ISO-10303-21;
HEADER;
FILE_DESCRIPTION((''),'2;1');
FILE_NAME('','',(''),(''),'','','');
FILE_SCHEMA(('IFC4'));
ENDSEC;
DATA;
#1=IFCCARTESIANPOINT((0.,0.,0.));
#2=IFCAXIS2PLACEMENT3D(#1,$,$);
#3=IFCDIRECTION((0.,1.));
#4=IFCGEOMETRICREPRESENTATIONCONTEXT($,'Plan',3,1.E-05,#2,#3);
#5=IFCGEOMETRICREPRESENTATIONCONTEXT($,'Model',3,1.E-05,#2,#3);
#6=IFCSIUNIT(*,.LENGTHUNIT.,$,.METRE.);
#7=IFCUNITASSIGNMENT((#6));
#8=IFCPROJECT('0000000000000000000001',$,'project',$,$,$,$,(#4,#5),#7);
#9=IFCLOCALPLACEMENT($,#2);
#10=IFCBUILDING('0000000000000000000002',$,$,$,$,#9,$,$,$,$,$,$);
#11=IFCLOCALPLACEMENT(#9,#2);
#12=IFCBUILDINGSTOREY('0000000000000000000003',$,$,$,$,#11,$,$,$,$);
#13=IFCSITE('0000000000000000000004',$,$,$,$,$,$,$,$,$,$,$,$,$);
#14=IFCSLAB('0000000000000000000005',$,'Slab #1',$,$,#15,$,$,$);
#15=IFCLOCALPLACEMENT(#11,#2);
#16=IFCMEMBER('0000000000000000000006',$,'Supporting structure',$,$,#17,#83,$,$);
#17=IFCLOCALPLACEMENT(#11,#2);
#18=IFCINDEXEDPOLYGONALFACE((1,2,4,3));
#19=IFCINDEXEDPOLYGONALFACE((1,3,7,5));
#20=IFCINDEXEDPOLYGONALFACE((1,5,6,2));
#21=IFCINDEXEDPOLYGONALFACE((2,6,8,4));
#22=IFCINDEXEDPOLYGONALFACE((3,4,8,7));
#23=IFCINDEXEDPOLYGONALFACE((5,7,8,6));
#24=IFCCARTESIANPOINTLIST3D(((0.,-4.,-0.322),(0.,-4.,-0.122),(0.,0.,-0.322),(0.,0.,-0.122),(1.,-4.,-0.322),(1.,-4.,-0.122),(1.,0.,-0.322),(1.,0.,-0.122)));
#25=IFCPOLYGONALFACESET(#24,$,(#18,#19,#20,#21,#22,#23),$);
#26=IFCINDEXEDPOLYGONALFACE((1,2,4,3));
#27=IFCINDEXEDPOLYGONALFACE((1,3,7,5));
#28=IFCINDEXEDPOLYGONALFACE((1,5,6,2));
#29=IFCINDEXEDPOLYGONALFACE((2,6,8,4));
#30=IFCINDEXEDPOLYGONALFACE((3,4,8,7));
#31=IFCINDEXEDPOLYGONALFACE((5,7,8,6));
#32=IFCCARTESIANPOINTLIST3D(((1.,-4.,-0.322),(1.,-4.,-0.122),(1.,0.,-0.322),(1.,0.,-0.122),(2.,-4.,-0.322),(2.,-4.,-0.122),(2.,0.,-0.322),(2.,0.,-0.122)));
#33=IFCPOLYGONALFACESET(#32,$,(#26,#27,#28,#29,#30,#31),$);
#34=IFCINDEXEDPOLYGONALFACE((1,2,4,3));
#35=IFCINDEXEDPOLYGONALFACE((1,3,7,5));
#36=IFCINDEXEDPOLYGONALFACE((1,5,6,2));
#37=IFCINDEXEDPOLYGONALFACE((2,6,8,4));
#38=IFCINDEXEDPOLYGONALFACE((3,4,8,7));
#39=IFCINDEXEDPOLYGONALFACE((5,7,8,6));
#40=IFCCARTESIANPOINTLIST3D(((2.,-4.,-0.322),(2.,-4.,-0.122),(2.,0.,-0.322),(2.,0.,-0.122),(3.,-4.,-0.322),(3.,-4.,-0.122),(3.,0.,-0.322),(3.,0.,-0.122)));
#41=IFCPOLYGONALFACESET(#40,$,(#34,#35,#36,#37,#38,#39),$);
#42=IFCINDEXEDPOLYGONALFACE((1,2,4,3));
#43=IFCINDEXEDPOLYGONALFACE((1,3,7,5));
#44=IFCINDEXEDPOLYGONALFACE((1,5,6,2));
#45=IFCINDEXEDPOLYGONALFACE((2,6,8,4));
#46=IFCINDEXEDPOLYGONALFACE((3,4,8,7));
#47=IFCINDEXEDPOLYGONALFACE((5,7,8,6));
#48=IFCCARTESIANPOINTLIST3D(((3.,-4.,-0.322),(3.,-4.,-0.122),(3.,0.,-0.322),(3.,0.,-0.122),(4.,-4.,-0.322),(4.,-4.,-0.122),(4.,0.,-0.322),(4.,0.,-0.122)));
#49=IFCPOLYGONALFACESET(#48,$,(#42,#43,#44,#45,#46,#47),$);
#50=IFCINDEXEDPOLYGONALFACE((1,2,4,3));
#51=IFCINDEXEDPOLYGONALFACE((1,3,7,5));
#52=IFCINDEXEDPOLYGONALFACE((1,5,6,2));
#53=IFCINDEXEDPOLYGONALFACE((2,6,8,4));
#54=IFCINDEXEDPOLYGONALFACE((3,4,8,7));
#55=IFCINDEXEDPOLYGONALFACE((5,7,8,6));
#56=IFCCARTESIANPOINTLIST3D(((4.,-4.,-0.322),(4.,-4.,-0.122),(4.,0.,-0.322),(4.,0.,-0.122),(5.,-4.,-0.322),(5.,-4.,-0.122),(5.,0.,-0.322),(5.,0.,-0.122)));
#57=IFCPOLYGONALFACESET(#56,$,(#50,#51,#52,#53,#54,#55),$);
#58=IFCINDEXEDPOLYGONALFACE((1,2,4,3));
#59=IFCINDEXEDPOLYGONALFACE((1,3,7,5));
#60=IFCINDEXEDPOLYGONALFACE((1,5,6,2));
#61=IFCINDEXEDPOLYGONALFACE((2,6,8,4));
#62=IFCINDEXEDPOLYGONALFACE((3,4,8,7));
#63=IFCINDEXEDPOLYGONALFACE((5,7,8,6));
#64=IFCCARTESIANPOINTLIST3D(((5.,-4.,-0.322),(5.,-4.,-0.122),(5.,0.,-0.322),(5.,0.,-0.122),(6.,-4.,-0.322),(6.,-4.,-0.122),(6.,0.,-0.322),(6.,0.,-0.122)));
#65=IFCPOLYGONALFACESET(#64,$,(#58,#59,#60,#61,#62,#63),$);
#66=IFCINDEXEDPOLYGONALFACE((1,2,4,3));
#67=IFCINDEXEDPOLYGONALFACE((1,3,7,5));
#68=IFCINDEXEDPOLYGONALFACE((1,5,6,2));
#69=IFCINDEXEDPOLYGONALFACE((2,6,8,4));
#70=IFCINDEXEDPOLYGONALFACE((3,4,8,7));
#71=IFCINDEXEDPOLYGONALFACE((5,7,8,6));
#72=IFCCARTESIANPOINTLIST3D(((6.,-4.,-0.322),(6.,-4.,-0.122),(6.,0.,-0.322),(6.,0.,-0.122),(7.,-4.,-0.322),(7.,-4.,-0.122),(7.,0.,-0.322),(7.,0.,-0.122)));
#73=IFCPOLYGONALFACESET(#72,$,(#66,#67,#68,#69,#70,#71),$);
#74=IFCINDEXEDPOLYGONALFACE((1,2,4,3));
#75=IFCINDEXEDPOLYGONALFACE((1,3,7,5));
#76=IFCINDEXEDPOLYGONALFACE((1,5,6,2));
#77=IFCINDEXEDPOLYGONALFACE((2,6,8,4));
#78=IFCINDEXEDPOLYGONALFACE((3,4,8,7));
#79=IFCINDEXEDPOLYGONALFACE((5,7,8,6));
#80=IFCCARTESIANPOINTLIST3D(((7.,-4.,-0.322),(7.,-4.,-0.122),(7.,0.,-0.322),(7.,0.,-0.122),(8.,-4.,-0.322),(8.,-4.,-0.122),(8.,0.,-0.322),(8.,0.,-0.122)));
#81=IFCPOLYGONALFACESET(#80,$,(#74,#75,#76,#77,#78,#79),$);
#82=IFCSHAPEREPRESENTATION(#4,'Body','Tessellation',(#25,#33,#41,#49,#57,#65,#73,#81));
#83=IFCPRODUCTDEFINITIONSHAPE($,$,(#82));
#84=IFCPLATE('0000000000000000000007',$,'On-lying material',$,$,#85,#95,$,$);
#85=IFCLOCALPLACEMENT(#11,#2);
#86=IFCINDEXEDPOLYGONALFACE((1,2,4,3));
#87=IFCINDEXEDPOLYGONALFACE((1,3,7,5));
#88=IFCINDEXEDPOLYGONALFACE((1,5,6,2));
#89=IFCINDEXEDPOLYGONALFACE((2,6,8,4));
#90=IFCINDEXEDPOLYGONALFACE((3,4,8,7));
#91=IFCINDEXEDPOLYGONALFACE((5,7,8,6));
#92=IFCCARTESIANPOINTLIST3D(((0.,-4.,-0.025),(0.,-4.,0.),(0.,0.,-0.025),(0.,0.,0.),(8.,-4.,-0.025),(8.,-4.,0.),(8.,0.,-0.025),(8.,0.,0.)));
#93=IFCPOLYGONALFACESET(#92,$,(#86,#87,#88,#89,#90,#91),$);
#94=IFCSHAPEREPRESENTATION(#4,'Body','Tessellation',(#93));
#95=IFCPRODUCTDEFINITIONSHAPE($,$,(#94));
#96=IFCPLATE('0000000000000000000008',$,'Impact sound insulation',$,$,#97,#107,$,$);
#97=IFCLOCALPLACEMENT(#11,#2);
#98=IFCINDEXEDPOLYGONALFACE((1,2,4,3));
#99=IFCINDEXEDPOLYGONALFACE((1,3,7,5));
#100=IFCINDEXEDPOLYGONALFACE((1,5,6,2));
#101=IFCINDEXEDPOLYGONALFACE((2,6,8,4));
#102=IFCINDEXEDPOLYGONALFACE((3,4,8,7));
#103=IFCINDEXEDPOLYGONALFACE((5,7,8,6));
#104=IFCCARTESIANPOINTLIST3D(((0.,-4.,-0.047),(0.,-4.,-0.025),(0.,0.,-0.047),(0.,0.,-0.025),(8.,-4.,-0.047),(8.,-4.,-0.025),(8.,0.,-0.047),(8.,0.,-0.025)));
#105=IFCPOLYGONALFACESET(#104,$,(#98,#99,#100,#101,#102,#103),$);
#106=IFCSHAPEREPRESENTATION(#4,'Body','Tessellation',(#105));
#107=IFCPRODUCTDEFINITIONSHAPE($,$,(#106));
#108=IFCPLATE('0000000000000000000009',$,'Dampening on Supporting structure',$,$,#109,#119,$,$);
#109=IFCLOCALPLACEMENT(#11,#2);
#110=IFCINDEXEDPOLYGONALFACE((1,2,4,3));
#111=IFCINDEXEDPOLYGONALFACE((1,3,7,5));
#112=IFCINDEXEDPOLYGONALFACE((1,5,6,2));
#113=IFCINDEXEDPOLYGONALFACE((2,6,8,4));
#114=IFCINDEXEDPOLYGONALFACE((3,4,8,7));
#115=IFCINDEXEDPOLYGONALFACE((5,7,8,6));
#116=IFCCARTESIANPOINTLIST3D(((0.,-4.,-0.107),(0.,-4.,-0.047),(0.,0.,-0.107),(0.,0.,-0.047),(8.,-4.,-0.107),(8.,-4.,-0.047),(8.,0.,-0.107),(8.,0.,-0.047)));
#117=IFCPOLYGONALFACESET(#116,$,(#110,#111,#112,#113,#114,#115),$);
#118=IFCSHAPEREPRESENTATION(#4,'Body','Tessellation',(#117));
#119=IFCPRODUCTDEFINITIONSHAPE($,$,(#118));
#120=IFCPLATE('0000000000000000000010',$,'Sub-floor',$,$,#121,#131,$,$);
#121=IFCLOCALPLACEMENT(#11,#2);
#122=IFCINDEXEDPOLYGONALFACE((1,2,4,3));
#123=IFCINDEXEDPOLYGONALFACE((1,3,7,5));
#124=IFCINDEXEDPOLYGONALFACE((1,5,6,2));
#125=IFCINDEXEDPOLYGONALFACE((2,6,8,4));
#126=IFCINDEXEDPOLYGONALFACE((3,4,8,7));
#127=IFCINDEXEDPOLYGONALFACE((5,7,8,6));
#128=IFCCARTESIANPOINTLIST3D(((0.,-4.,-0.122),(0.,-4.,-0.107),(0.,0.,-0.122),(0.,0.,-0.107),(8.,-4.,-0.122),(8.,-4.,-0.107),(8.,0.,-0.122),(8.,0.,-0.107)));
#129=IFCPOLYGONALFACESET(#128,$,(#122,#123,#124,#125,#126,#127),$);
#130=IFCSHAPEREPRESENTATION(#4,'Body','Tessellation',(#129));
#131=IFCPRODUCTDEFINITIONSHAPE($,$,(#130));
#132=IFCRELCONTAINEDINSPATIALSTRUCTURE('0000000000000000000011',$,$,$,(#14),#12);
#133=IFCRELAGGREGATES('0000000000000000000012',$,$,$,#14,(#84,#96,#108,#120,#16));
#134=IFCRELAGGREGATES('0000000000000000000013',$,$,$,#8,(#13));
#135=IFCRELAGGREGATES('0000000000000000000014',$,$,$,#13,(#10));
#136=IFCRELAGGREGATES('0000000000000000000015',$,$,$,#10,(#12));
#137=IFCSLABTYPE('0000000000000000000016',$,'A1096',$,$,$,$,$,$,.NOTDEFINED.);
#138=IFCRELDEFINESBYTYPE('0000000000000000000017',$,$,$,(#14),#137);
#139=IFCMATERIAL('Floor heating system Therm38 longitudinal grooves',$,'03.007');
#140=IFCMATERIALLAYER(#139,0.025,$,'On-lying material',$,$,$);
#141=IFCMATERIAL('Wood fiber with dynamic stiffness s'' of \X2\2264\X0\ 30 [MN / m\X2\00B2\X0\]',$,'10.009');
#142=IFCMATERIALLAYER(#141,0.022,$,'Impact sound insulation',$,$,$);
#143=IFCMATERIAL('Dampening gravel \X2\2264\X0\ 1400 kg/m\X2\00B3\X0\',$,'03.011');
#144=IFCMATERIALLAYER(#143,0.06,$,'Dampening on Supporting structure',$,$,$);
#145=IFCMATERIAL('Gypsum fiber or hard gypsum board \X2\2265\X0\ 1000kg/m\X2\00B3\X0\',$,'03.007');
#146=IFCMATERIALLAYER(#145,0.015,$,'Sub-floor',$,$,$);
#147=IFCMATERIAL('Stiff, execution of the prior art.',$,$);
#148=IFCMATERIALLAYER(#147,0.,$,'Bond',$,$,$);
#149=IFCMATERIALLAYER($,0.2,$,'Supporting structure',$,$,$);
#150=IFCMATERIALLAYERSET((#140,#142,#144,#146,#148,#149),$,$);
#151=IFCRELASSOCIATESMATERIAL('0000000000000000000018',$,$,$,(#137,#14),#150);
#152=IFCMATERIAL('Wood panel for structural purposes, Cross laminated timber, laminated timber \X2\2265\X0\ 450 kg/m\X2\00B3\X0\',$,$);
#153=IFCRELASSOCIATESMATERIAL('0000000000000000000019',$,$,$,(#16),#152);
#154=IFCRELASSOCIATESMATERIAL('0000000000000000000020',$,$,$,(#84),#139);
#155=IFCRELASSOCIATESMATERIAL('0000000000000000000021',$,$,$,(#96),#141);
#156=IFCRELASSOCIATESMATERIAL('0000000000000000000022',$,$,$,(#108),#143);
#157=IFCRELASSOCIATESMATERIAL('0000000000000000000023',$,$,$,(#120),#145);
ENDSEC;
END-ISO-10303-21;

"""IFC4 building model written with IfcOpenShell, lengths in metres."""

from ifc_helpers import new_model, si_unit, direction, frame, frame_2d, origin, origin_with_axes, place, context, project, spatial, rectangle, extrude, material, layer, layer_set, type_object, element, aggregate, save


model = new_model("IFC4")

# Units and contexts
plan_context = context("Plan", 3, precision=1e-05, world=origin(), true_north=direction((0.0, 1.0)))
model_context = context("Model", 3, precision=1e-05, world=origin(), true_north=direction((0.0, 1.0)))
ifc_project = project(units=[si_unit("LENGTHUNIT", "METRE")], contexts=[plan_context, model_context])

# Site, building, storey
site = spatial("IfcSite", under=ifc_project)
building_placement = place(None, origin())
building = spatial("IfcBuilding", under=site, at=building_placement)
storey_placement = place(building_placement, origin())
storey = spatial("IfcBuildingStorey", under=building, at=storey_placement)

# Slab, member, plates
ifc_material_1 = material(Name="Floor heating system Therm38 longitudinal grooves", Category="03.007")
ifc_layer_1 = layer(ifc_material_1, 0.025, Name="On-lying material")
ifc_material_2 = material(Name="Wood fiber with dynamic stiffness s' of ≤ 30 [MN / m²]", Category="10.009")
ifc_layer_2 = layer(ifc_material_2, 0.022, Name="Impact sound insulation")
ifc_material_3 = material(Name="Dampening gravel ≤ 1400 kg/m³", Category="03.011")
ifc_layer_3 = layer(ifc_material_3, 0.06, Name="Dampening on Supporting structure")
ifc_material_4 = material(Name="Gypsum fiber or hard gypsum board ≥ 1000kg/m³", Category="03.007")
ifc_layer_4 = layer(ifc_material_4, 0.015, Name="Sub-floor")
ifc_material_5 = material(Name="Stiff, execution of the prior art.")
ifc_layer_5 = layer(ifc_material_5, 0.0, Name="Bond")
ifc_layer_6 = layer(None, 0.2, Name="Supporting structure")
ifc_layer_set = layer_set([ifc_layer_1, ifc_layer_2, ifc_layer_3, ifc_layer_4, ifc_layer_5, ifc_layer_6])
slab_type = type_object("IfcSlabType", Name="A1096", PredefinedType="NOTDEFINED", material=ifc_layer_set)
slab_placement = place(None, frame((0.0, 0.0, 0.0), z_axis=(0.0, 0.0, -1.0), x_axis=(1.0, 0.0, 0.0)))
slab = element("IfcSlab", 1, at=slab_placement, inside=storey, type_object=slab_type, material=ifc_layer_set, Name="Slab #1")
ifc_material_6 = material(Name="Wood panel for structural purposes, Cross laminated timber, laminated timber ≥ 450 kg/m³")
member_placement = place(slab_placement, origin())
member = element("IfcMember", 2, at=member_placement, material=ifc_material_6, Name="Supporting structure", context=plan_context, shape_type="SweptSolid", body=[
    extrude(rectangle(XDim=1.0, YDim=0.2, at=frame_2d((0.5, 0.1), x_axis=(1.0, 0.0))), frame((0.0, 4.0, 0.122), z_axis=(0.0, -1.0, 0.0), x_axis=(1.0, 0.0, 0.0)), (0.0, 0.0, 1.0), 4.0),
    extrude(rectangle(XDim=1.0, YDim=0.2, at=frame_2d((0.5, 0.1), x_axis=(1.0, 0.0))), frame((1.0, 4.0, 0.122), z_axis=(0.0, -1.0, 0.0), x_axis=(1.0, 0.0, 0.0)), (0.0, 0.0, 1.0), 4.0),
    extrude(rectangle(XDim=1.0, YDim=0.2, at=frame_2d((0.5, 0.1), x_axis=(1.0, 0.0))), frame((2.0, 4.0, 0.122), z_axis=(0.0, -1.0, 0.0), x_axis=(1.0, 0.0, 0.0)), (0.0, 0.0, 1.0), 4.0),
    extrude(rectangle(XDim=1.0, YDim=0.2, at=frame_2d((0.5, 0.1), x_axis=(1.0, 0.0))), frame((3.0, 4.0, 0.122), z_axis=(0.0, -1.0, 0.0), x_axis=(1.0, 0.0, 0.0)), (0.0, 0.0, 1.0), 4.0),
    extrude(rectangle(XDim=1.0, YDim=0.2, at=frame_2d((0.5, 0.1), x_axis=(1.0, 0.0))), frame((4.0, 4.0, 0.122), z_axis=(0.0, -1.0, 0.0), x_axis=(1.0, 0.0, 0.0)), (0.0, 0.0, 1.0), 4.0),
    extrude(rectangle(XDim=1.0, YDim=0.2, at=frame_2d((0.5, 0.1), x_axis=(1.0, 0.0))), frame((5.0, 4.0, 0.122), z_axis=(0.0, -1.0, 0.0), x_axis=(1.0, 0.0, 0.0)), (0.0, 0.0, 1.0), 4.0),
    extrude(rectangle(XDim=1.0, YDim=0.2, at=frame_2d((0.5, 0.1), x_axis=(1.0, 0.0))), frame((6.0, 4.0, 0.122), z_axis=(0.0, -1.0, 0.0), x_axis=(1.0, 0.0, 0.0)), (0.0, 0.0, 1.0), 4.0),
    extrude(rectangle(XDim=1.0, YDim=0.2, at=frame_2d((0.5, 0.1), x_axis=(1.0, 0.0))), frame((7.0, 4.0, 0.122), z_axis=(0.0, -1.0, 0.0), x_axis=(1.0, 0.0, 0.0)), (0.0, 0.0, 1.0), 4.0),
])
plate_1_placement = place(slab_placement, origin())
plate_1 = element("IfcPlate", 3, at=plate_1_placement, material=ifc_material_1, Name="On-lying material", context=plan_context, shape_type="SweptSolid", body=[
    extrude(rectangle(XDim=8.0, YDim=4.0, at=frame_2d((4.0, 2.0), x_axis=(1.0, 0.0))), origin_with_axes(), (0.0, 0.0, 1.0), 0.025),
])
plate_2_placement = place(slab_placement, origin())
plate_2 = element("IfcPlate", 4, at=plate_2_placement, material=ifc_material_2, Name="Impact sound insulation", context=plan_context, shape_type="SweptSolid", body=[
    extrude(rectangle(XDim=8.0, YDim=4.0, at=frame_2d((4.0, 2.0), x_axis=(1.0, 0.0))), frame((0.0, 0.0, 0.025), z_axis=(0.0, 0.0, 1.0), x_axis=(1.0, 0.0, 0.0)), (0.0, 0.0, 1.0), 0.022),
])
plate_3_placement = place(slab_placement, origin())
plate_3 = element("IfcPlate", 5, at=plate_3_placement, material=ifc_material_3, Name="Dampening on Supporting structure", context=plan_context, shape_type="SweptSolid", body=[
    extrude(rectangle(XDim=8.0, YDim=4.0, at=frame_2d((4.0, 2.0), x_axis=(1.0, 0.0))), frame((0.0, 0.0, 0.047), z_axis=(0.0, 0.0, 1.0), x_axis=(1.0, 0.0, 0.0)), (0.0, 0.0, 1.0), 0.06),
])
plate_4_placement = place(slab_placement, origin())
plate_4 = element("IfcPlate", 6, at=plate_4_placement, material=ifc_material_4, Name="Sub-floor", context=plan_context, shape_type="SweptSolid", body=[
    extrude(rectangle(XDim=8.0, YDim=4.0, at=frame_2d((4.0, 2.0), x_axis=(1.0, 0.0))), frame((0.0, 0.0, 0.107), z_axis=(0.0, 0.0, 1.0), x_axis=(1.0, 0.0, 0.0)), (0.0, 0.0, 1.0), 0.015),
])
aggregate(slab, [plate_1, plate_2, plate_3, plate_4, member])

save(model, "model.ifc")
